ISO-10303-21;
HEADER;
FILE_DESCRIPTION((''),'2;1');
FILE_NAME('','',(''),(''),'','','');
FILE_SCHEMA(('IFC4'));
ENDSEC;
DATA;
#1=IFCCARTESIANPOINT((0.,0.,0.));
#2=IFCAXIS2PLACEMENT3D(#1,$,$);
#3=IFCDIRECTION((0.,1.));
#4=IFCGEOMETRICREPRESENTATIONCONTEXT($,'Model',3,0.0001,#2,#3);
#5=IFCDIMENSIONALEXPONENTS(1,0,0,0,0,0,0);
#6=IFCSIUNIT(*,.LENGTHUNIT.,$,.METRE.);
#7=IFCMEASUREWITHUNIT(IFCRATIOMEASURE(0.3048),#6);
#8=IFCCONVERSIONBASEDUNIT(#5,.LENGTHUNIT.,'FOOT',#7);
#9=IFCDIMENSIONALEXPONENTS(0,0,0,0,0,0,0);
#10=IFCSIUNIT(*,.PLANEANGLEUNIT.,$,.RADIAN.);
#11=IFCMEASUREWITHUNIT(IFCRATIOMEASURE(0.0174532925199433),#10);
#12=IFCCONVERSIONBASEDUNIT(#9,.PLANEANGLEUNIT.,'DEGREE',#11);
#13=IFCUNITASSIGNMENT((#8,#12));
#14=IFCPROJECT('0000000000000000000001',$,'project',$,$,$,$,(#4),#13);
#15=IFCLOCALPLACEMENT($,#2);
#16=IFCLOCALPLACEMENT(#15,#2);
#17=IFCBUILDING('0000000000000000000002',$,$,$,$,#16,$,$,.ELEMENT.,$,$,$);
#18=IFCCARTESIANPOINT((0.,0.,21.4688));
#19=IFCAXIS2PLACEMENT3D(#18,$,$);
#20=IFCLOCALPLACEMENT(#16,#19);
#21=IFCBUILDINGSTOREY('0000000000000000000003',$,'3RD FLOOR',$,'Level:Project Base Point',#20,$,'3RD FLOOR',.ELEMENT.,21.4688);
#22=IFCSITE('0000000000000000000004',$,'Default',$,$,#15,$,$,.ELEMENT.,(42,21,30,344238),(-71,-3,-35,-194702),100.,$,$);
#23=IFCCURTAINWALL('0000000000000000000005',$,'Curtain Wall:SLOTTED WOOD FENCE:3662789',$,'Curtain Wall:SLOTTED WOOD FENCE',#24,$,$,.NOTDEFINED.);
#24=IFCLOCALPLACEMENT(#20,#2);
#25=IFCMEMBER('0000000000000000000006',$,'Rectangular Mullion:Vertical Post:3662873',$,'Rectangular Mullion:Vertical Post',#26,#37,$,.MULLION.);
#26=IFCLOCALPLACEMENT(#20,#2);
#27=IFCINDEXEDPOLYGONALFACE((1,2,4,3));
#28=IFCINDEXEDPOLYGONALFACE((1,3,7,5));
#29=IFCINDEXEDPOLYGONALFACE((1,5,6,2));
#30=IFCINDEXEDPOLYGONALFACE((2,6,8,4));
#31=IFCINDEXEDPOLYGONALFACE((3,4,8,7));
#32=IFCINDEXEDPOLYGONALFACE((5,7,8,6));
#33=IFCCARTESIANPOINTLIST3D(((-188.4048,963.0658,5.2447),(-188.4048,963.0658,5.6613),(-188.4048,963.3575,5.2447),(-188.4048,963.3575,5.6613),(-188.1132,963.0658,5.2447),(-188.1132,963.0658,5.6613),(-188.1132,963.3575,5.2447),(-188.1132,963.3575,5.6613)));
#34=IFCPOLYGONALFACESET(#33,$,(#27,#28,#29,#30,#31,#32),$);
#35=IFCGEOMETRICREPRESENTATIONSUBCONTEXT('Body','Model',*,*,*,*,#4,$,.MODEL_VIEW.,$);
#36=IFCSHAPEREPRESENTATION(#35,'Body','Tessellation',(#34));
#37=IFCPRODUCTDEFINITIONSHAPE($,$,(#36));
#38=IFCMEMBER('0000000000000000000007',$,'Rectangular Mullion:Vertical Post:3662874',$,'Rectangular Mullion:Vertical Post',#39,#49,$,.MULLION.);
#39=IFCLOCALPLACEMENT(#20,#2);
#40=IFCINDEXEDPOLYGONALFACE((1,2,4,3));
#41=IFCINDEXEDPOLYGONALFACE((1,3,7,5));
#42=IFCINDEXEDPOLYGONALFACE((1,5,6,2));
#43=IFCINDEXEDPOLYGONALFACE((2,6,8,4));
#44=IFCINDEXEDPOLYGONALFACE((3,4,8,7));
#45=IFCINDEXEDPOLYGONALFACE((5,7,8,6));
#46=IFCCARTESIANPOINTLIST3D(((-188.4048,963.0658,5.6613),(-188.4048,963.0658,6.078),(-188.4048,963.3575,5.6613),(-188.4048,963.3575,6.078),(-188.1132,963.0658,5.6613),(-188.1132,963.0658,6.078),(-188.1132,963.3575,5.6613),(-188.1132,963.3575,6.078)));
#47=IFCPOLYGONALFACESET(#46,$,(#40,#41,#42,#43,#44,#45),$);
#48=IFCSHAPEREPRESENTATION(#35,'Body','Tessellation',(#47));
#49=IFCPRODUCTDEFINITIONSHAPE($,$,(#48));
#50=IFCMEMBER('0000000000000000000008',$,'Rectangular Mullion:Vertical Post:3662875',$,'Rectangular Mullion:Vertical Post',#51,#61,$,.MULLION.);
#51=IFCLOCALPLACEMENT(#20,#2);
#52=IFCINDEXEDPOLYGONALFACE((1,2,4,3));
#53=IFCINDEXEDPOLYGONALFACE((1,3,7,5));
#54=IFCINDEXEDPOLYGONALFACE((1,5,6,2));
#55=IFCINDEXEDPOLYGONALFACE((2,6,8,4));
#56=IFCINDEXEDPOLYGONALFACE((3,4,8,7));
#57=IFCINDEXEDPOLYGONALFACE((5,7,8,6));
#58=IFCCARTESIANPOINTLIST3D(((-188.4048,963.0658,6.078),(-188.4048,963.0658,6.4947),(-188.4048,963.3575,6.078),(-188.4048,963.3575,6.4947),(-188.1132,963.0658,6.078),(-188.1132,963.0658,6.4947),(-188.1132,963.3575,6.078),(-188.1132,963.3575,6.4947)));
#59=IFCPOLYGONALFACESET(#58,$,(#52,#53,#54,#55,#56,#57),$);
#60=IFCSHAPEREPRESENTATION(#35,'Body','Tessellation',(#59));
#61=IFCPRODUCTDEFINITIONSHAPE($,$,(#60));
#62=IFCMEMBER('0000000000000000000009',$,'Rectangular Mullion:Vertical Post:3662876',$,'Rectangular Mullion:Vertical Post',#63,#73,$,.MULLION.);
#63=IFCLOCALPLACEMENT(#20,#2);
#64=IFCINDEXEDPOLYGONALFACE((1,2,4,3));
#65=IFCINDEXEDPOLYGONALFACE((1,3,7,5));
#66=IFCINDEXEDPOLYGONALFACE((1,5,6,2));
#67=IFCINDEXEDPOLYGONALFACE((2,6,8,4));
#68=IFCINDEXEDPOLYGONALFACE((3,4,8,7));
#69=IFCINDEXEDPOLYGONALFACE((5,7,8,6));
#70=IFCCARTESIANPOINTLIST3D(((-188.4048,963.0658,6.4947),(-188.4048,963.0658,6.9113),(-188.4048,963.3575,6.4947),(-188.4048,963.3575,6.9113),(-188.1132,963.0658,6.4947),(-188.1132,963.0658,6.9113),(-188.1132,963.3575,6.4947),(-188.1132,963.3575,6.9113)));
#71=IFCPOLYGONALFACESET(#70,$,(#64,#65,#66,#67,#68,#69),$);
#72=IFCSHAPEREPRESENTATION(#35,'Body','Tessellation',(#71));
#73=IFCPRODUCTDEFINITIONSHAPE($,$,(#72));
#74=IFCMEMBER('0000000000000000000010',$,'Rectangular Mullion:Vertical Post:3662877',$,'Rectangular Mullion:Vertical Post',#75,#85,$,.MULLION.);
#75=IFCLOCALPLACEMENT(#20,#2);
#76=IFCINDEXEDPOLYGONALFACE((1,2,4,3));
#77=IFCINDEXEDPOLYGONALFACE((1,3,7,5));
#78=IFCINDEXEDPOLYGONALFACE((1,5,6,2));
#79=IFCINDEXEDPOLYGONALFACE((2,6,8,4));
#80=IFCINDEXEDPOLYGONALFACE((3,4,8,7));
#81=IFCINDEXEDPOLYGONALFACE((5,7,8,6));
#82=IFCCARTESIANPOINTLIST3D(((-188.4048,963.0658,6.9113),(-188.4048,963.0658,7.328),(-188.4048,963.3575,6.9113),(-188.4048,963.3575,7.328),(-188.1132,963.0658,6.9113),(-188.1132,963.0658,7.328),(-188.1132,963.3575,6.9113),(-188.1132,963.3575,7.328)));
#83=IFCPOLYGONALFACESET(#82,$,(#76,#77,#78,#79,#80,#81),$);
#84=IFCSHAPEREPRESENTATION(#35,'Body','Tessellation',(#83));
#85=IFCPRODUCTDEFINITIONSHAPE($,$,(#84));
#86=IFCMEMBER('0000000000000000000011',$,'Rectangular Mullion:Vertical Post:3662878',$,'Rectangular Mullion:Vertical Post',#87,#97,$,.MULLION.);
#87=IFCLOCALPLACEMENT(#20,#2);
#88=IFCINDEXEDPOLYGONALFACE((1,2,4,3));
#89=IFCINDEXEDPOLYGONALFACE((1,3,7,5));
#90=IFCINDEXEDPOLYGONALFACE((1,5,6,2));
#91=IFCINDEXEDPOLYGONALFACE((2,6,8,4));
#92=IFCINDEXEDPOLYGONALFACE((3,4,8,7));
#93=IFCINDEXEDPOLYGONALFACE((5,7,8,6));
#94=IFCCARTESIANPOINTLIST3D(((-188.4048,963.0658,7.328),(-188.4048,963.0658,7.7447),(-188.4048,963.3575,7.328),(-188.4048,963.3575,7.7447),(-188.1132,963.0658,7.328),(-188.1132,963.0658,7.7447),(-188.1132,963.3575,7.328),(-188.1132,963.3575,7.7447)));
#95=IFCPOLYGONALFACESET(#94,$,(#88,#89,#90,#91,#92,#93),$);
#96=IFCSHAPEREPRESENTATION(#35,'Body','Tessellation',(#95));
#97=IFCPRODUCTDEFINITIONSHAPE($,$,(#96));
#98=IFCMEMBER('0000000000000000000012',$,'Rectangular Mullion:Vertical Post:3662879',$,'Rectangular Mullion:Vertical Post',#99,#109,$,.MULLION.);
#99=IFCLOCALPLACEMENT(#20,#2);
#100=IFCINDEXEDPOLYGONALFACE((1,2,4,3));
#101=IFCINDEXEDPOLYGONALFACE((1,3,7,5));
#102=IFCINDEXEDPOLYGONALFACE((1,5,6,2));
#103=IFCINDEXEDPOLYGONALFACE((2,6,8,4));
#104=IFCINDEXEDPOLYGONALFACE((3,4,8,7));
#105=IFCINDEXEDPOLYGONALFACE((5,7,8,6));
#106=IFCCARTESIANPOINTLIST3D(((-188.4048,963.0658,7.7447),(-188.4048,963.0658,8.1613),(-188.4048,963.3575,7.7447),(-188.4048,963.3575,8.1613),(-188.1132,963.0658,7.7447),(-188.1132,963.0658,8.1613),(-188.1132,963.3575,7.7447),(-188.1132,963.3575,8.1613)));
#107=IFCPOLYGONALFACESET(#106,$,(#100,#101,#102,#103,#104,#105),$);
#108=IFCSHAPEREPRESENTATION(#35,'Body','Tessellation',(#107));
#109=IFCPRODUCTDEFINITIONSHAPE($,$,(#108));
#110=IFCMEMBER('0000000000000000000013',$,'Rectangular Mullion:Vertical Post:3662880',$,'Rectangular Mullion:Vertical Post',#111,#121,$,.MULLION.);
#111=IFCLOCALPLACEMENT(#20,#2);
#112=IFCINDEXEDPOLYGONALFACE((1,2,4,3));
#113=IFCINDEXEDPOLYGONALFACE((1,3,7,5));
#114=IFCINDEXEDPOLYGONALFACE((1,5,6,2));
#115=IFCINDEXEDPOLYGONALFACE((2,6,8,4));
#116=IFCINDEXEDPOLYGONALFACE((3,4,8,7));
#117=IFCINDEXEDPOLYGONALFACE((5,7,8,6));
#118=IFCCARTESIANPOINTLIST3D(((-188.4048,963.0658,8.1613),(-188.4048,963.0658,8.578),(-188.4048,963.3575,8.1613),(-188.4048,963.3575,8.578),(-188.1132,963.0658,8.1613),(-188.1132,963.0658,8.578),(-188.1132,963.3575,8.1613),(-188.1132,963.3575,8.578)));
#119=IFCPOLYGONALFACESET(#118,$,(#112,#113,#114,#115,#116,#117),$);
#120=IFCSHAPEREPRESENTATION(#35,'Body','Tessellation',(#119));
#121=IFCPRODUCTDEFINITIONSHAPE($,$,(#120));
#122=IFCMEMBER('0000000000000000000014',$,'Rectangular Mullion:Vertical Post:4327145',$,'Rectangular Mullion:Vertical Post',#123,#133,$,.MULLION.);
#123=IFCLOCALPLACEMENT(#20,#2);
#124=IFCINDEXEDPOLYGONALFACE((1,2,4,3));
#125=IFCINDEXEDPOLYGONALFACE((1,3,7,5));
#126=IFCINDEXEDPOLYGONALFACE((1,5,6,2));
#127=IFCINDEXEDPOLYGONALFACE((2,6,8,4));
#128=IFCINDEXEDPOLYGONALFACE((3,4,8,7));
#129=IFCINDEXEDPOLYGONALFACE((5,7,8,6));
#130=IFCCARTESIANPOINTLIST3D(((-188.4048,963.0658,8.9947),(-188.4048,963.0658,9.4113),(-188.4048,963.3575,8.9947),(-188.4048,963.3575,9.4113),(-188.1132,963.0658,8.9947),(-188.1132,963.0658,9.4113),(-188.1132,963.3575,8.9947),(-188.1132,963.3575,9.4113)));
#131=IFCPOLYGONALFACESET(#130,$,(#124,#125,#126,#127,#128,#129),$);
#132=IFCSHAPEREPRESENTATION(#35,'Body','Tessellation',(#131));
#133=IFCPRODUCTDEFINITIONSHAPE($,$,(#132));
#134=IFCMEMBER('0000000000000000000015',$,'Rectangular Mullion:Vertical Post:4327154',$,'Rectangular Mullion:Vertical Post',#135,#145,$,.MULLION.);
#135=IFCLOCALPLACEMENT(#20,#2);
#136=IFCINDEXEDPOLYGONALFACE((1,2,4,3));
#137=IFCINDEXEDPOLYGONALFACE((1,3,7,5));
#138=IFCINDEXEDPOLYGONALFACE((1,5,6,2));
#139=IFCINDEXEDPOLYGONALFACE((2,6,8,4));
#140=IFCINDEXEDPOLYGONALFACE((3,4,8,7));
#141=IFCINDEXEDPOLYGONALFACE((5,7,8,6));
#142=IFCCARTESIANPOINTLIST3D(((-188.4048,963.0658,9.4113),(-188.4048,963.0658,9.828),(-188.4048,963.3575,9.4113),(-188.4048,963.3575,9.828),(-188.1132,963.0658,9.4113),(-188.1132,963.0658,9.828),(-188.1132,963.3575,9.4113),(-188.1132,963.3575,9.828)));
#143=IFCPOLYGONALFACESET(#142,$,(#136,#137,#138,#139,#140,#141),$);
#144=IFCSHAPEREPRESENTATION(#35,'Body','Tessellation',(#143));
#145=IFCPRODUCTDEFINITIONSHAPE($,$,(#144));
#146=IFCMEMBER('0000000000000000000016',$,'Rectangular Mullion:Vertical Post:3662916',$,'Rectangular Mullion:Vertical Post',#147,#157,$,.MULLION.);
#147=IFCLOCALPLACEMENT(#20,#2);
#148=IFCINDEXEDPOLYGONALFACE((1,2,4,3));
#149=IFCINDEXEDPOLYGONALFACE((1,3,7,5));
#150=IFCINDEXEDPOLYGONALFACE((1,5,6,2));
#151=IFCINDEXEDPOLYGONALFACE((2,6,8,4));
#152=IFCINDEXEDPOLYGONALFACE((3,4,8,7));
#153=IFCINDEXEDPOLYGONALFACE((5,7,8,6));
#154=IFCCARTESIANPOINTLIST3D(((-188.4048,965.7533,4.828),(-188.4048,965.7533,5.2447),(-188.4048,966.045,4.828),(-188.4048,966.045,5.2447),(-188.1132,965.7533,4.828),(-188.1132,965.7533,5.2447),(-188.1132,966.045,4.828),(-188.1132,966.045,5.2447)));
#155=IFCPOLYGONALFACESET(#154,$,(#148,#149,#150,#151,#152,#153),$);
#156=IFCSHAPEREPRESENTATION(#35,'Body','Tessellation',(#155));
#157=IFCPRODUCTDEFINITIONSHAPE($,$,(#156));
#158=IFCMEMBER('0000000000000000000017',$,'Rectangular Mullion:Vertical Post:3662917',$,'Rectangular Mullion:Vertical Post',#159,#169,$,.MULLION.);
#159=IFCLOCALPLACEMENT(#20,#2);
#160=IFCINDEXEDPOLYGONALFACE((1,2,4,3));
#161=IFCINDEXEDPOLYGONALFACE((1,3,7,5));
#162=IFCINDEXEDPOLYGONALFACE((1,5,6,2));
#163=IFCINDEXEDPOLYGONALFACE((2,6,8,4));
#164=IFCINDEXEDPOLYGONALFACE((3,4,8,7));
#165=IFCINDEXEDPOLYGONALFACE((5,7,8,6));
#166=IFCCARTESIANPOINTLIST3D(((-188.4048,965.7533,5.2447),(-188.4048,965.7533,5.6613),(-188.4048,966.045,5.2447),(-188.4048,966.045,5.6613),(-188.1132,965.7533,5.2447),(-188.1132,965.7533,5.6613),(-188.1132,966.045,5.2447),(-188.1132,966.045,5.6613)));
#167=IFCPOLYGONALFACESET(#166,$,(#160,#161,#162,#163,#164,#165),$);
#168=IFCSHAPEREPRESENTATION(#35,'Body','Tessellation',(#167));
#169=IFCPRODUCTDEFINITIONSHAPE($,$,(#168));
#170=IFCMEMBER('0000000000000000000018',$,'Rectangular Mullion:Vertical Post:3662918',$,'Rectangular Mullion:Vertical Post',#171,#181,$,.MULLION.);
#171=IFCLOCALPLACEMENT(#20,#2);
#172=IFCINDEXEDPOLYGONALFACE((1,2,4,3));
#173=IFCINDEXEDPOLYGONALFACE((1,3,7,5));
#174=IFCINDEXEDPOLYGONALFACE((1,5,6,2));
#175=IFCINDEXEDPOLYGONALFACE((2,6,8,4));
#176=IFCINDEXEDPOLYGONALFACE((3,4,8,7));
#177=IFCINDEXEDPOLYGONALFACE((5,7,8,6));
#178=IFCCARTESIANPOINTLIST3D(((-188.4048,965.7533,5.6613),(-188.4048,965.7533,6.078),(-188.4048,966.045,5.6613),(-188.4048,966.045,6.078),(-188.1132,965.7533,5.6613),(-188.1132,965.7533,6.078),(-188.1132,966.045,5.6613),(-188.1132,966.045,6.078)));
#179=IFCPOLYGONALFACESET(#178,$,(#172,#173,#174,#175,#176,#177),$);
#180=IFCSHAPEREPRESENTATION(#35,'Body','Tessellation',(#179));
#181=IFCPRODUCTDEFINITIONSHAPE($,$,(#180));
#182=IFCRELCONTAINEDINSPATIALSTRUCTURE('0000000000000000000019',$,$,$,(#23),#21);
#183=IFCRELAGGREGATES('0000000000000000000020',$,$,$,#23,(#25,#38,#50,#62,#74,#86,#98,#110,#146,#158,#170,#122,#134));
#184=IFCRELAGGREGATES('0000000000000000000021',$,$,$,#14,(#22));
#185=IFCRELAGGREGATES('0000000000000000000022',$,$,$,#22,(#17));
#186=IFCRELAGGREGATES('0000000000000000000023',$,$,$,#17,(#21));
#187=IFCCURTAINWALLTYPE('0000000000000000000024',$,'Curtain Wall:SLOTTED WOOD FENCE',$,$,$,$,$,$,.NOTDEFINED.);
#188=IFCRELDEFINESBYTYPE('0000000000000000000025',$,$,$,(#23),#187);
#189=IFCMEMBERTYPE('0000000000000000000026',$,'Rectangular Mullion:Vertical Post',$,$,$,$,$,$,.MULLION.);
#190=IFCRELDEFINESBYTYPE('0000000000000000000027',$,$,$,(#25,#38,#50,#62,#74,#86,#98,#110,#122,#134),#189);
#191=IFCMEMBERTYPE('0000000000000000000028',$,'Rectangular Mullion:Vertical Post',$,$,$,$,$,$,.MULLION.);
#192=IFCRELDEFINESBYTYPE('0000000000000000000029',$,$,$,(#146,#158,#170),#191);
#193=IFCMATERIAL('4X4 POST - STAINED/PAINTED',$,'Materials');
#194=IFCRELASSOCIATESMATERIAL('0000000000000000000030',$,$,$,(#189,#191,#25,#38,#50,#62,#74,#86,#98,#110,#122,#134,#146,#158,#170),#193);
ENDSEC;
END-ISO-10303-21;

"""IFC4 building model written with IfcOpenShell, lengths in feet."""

from ifc_helpers import new_model, entity, si_unit, converted_unit, direction, frame, origin, origin_2d_with_axis, place, context, subcontext, project, spatial, rectangle, extrude, source, transform, mapped, material, material_profile, profile_set, profile_usage, type_object, type_shapes, element, aggregate, save


model = new_model("IFC4")

# Units and contexts
model_context = context("Model", 3, precision=0.0001, world=origin(), true_north=direction((0.0, 1.0)))
body_context = subcontext(model_context, "Body", "Model", "MODEL_VIEW")
ifc_project = project(units=[converted_unit("LENGTHUNIT", "FOOT", entity("IfcRatioMeasure", 0.3048), si_unit("LENGTHUNIT", "METRE"), dimensions=[1, 0, 0, 0, 0, 0, 0]), converted_unit("PLANEANGLEUNIT", "DEGREE", entity("IfcRatioMeasure", 0.0174532925199433), si_unit("PLANEANGLEUNIT", "RADIAN"), dimensions=[0, 0, 0, 0, 0, 0, 0])], contexts=[model_context])

# Site, building, storey
site_placement = place(None, origin())
site = spatial("IfcSite", under=ifc_project, at=site_placement, Name="Default", CompositionType="ELEMENT", RefLatitude=(42, 21, 30, 344238), RefLongitude=(-71, -3, -35, -194702), RefElevation=100.0)
building_placement = place(site_placement, origin())
building = spatial("IfcBuilding", under=site, at=building_placement, CompositionType="ELEMENT")
storey_placement = place(building_placement, frame((0.0, 0.0, 21.4688)))
storey = spatial("IfcBuildingStorey", under=building, at=storey_placement, Name="3RD FLOOR", ObjectType="Level:Project Base Point", LongName="3RD FLOOR", CompositionType="ELEMENT", Elevation=21.4688)

# Curtain wall, members
curtain_wall_type = type_object("IfcCurtainWallType", Name="Curtain Wall:SLOTTED WOOD FENCE", PredefinedType="NOTDEFINED")
curtain_wall_placement = place(storey_placement, frame((0.0, 0.0, -21.4688)))
curtain_wall = element("IfcCurtainWall", 1, at=curtain_wall_placement, inside=storey, type_object=curtain_wall_type, Name="Curtain Wall:SLOTTED WOOD FENCE:3662789", ObjectType="Curtain Wall:SLOTTED WOOD FENCE", PredefinedType="NOTDEFINED")
ifc_material_1 = material(Name="4X4 POST - STAINED/PAINTED", Category="Materials")
ifc_material_profile = material_profile(ifc_material_1, rectangle(XDim=0.2917, YDim=0.2917, at=origin_2d_with_axis()), Name="Vertical Post")
ifc_profile_set = profile_set([ifc_material_profile], Name="Vertical Post")
ifc_profile_usage_1 = profile_usage(ifc_profile_set)
member_type_1 = type_object("IfcMemberType", Name="Rectangular Mullion:Vertical Post", PredefinedType="MULLION", material=ifc_profile_set)
shared_shape_1 = source(origin(), body_context, "Body", "SweptSolid", [
    extrude(rectangle(XDim=0.2917, YDim=0.2917, at=origin_2d_with_axis()), frame((-0.1458, 0.2083, -0.4167), z_axis=(0.0, 0.0, 1.0), x_axis=(0.0, -1.0, 0.0)), (0.0, 0.0, 1.0), 0.4167),
])
type_shapes(member_type_1, [shared_shape_1])
member_1_placement = place(storey_placement, frame((-188.0507, 963.0658, 5.2447), z_axis=(0.0, 0.0, -1.0), x_axis=(0.0, -1.0, 0.0)))
member_1 = element("IfcMember", 2, at=member_1_placement, type_object=member_type_1, material=ifc_profile_usage_1, Name="Rectangular Mullion:Vertical Post:3662873", ObjectType="Rectangular Mullion:Vertical Post", PredefinedType="MULLION", context=body_context, shape_type="MappedRepresentation", body=[
    mapped(shared_shape_1, transform((0.0, 0.0, 0.0), scale=1.0)),
])
ifc_profile_usage_2 = profile_usage(ifc_profile_set)
member_2_placement = place(storey_placement, frame((-188.0507, 963.0658, 5.6613), z_axis=(0.0, 0.0, -1.0), x_axis=(0.0, -1.0, 0.0)))
member_2 = element("IfcMember", 3, at=member_2_placement, type_object=member_type_1, material=ifc_profile_usage_2, Name="Rectangular Mullion:Vertical Post:3662874", ObjectType="Rectangular Mullion:Vertical Post", PredefinedType="MULLION", context=body_context, shape_type="MappedRepresentation", body=[
    mapped(shared_shape_1, transform((0.0, 0.0, 0.0), scale=1.0)),
])
ifc_profile_usage_3 = profile_usage(ifc_profile_set)
member_3_placement = place(storey_placement, frame((-188.0507, 963.0658, 6.078), z_axis=(0.0, 0.0, -1.0), x_axis=(0.0, -1.0, 0.0)))
member_3 = element("IfcMember", 4, at=member_3_placement, type_object=member_type_1, material=ifc_profile_usage_3, Name="Rectangular Mullion:Vertical Post:3662875", ObjectType="Rectangular Mullion:Vertical Post", PredefinedType="MULLION", context=body_context, shape_type="MappedRepresentation", body=[
    mapped(shared_shape_1, transform((0.0, 0.0, 0.0), scale=1.0)),
])
ifc_profile_usage_4 = profile_usage(ifc_profile_set)
member_4_placement = place(storey_placement, frame((-188.0507, 963.0658, 6.4947), z_axis=(0.0, 0.0, -1.0), x_axis=(0.0, -1.0, 0.0)))
member_4 = element("IfcMember", 5, at=member_4_placement, type_object=member_type_1, material=ifc_profile_usage_4, Name="Rectangular Mullion:Vertical Post:3662876", ObjectType="Rectangular Mullion:Vertical Post", PredefinedType="MULLION", context=body_context, shape_type="MappedRepresentation", body=[
    mapped(shared_shape_1, transform((0.0, 0.0, 0.0), scale=1.0)),
])
ifc_profile_usage_5 = profile_usage(ifc_profile_set)
member_5_placement = place(storey_placement, frame((-188.0507, 963.0658, 6.9113), z_axis=(0.0, 0.0, -1.0), x_axis=(0.0, -1.0, 0.0)))
member_5 = element("IfcMember", 6, at=member_5_placement, type_object=member_type_1, material=ifc_profile_usage_5, Name="Rectangular Mullion:Vertical Post:3662877", ObjectType="Rectangular Mullion:Vertical Post", PredefinedType="MULLION", context=body_context, shape_type="MappedRepresentation", body=[
    mapped(shared_shape_1, transform((0.0, 0.0, 0.0), scale=1.0)),
])
ifc_profile_usage_6 = profile_usage(ifc_profile_set)
member_6_placement = place(storey_placement, frame((-188.0507, 963.0658, 7.328), z_axis=(0.0, 0.0, -1.0), x_axis=(0.0, -1.0, 0.0)))
member_6 = element("IfcMember", 7, at=member_6_placement, type_object=member_type_1, material=ifc_profile_usage_6, Name="Rectangular Mullion:Vertical Post:3662878", ObjectType="Rectangular Mullion:Vertical Post", PredefinedType="MULLION", context=body_context, shape_type="MappedRepresentation", body=[
    mapped(shared_shape_1, transform((0.0, 0.0, 0.0), scale=1.0)),
])
ifc_profile_usage_7 = profile_usage(ifc_profile_set)
member_7_placement = place(storey_placement, frame((-188.0507, 963.0658, 7.7447), z_axis=(0.0, 0.0, -1.0), x_axis=(0.0, -1.0, 0.0)))
member_7 = element("IfcMember", 8, at=member_7_placement, type_object=member_type_1, material=ifc_profile_usage_7, Name="Rectangular Mullion:Vertical Post:3662879", ObjectType="Rectangular Mullion:Vertical Post", PredefinedType="MULLION", context=body_context, shape_type="MappedRepresentation", body=[
    mapped(shared_shape_1, transform((0.0, 0.0, 0.0), scale=1.0)),
])
ifc_profile_usage_8 = profile_usage(ifc_profile_set)
member_8_placement = place(storey_placement, frame((-188.0507, 963.0658, 8.1613), z_axis=(0.0, 0.0, -1.0), x_axis=(0.0, -1.0, 0.0)))
member_8 = element("IfcMember", 9, at=member_8_placement, type_object=member_type_1, material=ifc_profile_usage_8, Name="Rectangular Mullion:Vertical Post:3662880", ObjectType="Rectangular Mullion:Vertical Post", PredefinedType="MULLION", context=body_context, shape_type="MappedRepresentation", body=[
    mapped(shared_shape_1, transform((0.0, 0.0, 0.0), scale=1.0)),
])
ifc_profile_usage_9 = profile_usage(ifc_profile_set)
member_9_placement = place(storey_placement, frame((-188.0507, 963.0658, 8.9947), z_axis=(0.0, 0.0, -1.0), x_axis=(0.0, -1.0, 0.0)))
member_9 = element("IfcMember", 10, at=member_9_placement, type_object=member_type_1, material=ifc_profile_usage_9, Name="Rectangular Mullion:Vertical Post:4327145", ObjectType="Rectangular Mullion:Vertical Post", PredefinedType="MULLION", context=body_context, shape_type="MappedRepresentation", body=[
    mapped(shared_shape_1, transform((0.0, 0.0, 0.0), scale=1.0)),
])
ifc_profile_usage_10 = profile_usage(ifc_profile_set)
member_10_placement = place(storey_placement, frame((-188.0507, 963.0658, 9.4113), z_axis=(0.0, 0.0, -1.0), x_axis=(0.0, -1.0, 0.0)))
member_10 = element("IfcMember", 11, at=member_10_placement, type_object=member_type_1, material=ifc_profile_usage_10, Name="Rectangular Mullion:Vertical Post:4327154", ObjectType="Rectangular Mullion:Vertical Post", PredefinedType="MULLION", context=body_context, shape_type="MappedRepresentation", body=[
    mapped(shared_shape_1, transform((0.0, 0.0, 0.0), scale=1.0)),
])
ifc_profile_usage_11 = profile_usage(ifc_profile_set)
member_type_2 = type_object("IfcMemberType", Name="Rectangular Mullion:Vertical Post", PredefinedType="MULLION", material=ifc_profile_set)
shared_shape_2 = source(origin(), body_context, "Body", "SweptSolid", [
    extrude(rectangle(XDim=0.2917, YDim=0.2917, at=origin_2d_with_axis()), frame((0.0, 0.2083, -0.4167), z_axis=(0.0, 0.0, 1.0), x_axis=(0.0, -1.0, 0.0)), (0.0, 0.0, 1.0), 0.4167),
])
type_shapes(member_type_2, [shared_shape_2])
member_11_placement = place(storey_placement, frame((-188.0507, 965.8991, 4.828), z_axis=(0.0, 0.0, -1.0), x_axis=(0.0, -1.0, 0.0)))
member_11 = element("IfcMember", 12, at=member_11_placement, type_object=member_type_2, material=ifc_profile_usage_11, Name="Rectangular Mullion:Vertical Post:3662916", ObjectType="Rectangular Mullion:Vertical Post", PredefinedType="MULLION", context=body_context, shape_type="MappedRepresentation", body=[
    mapped(shared_shape_2, transform((0.0, 0.0, 0.0), scale=1.0)),
])
ifc_profile_usage_12 = profile_usage(ifc_profile_set)
member_12_placement = place(storey_placement, frame((-188.0507, 965.8991, 5.2447), z_axis=(0.0, 0.0, -1.0), x_axis=(0.0, -1.0, 0.0)))
member_12 = element("IfcMember", 13, at=member_12_placement, type_object=member_type_2, material=ifc_profile_usage_12, Name="Rectangular Mullion:Vertical Post:3662917", ObjectType="Rectangular Mullion:Vertical Post", PredefinedType="MULLION", context=body_context, shape_type="MappedRepresentation", body=[
    mapped(shared_shape_2, transform((0.0, 0.0, 0.0), scale=1.0)),
])
ifc_profile_usage_13 = profile_usage(ifc_profile_set)
member_13_placement = place(storey_placement, frame((-188.0507, 965.8991, 5.6613), z_axis=(0.0, 0.0, -1.0), x_axis=(0.0, -1.0, 0.0)))
member_13 = element("IfcMember", 14, at=member_13_placement, type_object=member_type_2, material=ifc_profile_usage_13, Name="Rectangular Mullion:Vertical Post:3662918", ObjectType="Rectangular Mullion:Vertical Post", PredefinedType="MULLION", context=body_context, shape_type="MappedRepresentation", body=[
    mapped(shared_shape_2, transform((0.0, 0.0, 0.0), scale=1.0)),
])
aggregate(curtain_wall, [member_1, member_2, member_3, member_4, member_5, member_6, member_7, member_8, member_11, member_12, member_13, member_9, member_10])

save(model, "model.ifc")
